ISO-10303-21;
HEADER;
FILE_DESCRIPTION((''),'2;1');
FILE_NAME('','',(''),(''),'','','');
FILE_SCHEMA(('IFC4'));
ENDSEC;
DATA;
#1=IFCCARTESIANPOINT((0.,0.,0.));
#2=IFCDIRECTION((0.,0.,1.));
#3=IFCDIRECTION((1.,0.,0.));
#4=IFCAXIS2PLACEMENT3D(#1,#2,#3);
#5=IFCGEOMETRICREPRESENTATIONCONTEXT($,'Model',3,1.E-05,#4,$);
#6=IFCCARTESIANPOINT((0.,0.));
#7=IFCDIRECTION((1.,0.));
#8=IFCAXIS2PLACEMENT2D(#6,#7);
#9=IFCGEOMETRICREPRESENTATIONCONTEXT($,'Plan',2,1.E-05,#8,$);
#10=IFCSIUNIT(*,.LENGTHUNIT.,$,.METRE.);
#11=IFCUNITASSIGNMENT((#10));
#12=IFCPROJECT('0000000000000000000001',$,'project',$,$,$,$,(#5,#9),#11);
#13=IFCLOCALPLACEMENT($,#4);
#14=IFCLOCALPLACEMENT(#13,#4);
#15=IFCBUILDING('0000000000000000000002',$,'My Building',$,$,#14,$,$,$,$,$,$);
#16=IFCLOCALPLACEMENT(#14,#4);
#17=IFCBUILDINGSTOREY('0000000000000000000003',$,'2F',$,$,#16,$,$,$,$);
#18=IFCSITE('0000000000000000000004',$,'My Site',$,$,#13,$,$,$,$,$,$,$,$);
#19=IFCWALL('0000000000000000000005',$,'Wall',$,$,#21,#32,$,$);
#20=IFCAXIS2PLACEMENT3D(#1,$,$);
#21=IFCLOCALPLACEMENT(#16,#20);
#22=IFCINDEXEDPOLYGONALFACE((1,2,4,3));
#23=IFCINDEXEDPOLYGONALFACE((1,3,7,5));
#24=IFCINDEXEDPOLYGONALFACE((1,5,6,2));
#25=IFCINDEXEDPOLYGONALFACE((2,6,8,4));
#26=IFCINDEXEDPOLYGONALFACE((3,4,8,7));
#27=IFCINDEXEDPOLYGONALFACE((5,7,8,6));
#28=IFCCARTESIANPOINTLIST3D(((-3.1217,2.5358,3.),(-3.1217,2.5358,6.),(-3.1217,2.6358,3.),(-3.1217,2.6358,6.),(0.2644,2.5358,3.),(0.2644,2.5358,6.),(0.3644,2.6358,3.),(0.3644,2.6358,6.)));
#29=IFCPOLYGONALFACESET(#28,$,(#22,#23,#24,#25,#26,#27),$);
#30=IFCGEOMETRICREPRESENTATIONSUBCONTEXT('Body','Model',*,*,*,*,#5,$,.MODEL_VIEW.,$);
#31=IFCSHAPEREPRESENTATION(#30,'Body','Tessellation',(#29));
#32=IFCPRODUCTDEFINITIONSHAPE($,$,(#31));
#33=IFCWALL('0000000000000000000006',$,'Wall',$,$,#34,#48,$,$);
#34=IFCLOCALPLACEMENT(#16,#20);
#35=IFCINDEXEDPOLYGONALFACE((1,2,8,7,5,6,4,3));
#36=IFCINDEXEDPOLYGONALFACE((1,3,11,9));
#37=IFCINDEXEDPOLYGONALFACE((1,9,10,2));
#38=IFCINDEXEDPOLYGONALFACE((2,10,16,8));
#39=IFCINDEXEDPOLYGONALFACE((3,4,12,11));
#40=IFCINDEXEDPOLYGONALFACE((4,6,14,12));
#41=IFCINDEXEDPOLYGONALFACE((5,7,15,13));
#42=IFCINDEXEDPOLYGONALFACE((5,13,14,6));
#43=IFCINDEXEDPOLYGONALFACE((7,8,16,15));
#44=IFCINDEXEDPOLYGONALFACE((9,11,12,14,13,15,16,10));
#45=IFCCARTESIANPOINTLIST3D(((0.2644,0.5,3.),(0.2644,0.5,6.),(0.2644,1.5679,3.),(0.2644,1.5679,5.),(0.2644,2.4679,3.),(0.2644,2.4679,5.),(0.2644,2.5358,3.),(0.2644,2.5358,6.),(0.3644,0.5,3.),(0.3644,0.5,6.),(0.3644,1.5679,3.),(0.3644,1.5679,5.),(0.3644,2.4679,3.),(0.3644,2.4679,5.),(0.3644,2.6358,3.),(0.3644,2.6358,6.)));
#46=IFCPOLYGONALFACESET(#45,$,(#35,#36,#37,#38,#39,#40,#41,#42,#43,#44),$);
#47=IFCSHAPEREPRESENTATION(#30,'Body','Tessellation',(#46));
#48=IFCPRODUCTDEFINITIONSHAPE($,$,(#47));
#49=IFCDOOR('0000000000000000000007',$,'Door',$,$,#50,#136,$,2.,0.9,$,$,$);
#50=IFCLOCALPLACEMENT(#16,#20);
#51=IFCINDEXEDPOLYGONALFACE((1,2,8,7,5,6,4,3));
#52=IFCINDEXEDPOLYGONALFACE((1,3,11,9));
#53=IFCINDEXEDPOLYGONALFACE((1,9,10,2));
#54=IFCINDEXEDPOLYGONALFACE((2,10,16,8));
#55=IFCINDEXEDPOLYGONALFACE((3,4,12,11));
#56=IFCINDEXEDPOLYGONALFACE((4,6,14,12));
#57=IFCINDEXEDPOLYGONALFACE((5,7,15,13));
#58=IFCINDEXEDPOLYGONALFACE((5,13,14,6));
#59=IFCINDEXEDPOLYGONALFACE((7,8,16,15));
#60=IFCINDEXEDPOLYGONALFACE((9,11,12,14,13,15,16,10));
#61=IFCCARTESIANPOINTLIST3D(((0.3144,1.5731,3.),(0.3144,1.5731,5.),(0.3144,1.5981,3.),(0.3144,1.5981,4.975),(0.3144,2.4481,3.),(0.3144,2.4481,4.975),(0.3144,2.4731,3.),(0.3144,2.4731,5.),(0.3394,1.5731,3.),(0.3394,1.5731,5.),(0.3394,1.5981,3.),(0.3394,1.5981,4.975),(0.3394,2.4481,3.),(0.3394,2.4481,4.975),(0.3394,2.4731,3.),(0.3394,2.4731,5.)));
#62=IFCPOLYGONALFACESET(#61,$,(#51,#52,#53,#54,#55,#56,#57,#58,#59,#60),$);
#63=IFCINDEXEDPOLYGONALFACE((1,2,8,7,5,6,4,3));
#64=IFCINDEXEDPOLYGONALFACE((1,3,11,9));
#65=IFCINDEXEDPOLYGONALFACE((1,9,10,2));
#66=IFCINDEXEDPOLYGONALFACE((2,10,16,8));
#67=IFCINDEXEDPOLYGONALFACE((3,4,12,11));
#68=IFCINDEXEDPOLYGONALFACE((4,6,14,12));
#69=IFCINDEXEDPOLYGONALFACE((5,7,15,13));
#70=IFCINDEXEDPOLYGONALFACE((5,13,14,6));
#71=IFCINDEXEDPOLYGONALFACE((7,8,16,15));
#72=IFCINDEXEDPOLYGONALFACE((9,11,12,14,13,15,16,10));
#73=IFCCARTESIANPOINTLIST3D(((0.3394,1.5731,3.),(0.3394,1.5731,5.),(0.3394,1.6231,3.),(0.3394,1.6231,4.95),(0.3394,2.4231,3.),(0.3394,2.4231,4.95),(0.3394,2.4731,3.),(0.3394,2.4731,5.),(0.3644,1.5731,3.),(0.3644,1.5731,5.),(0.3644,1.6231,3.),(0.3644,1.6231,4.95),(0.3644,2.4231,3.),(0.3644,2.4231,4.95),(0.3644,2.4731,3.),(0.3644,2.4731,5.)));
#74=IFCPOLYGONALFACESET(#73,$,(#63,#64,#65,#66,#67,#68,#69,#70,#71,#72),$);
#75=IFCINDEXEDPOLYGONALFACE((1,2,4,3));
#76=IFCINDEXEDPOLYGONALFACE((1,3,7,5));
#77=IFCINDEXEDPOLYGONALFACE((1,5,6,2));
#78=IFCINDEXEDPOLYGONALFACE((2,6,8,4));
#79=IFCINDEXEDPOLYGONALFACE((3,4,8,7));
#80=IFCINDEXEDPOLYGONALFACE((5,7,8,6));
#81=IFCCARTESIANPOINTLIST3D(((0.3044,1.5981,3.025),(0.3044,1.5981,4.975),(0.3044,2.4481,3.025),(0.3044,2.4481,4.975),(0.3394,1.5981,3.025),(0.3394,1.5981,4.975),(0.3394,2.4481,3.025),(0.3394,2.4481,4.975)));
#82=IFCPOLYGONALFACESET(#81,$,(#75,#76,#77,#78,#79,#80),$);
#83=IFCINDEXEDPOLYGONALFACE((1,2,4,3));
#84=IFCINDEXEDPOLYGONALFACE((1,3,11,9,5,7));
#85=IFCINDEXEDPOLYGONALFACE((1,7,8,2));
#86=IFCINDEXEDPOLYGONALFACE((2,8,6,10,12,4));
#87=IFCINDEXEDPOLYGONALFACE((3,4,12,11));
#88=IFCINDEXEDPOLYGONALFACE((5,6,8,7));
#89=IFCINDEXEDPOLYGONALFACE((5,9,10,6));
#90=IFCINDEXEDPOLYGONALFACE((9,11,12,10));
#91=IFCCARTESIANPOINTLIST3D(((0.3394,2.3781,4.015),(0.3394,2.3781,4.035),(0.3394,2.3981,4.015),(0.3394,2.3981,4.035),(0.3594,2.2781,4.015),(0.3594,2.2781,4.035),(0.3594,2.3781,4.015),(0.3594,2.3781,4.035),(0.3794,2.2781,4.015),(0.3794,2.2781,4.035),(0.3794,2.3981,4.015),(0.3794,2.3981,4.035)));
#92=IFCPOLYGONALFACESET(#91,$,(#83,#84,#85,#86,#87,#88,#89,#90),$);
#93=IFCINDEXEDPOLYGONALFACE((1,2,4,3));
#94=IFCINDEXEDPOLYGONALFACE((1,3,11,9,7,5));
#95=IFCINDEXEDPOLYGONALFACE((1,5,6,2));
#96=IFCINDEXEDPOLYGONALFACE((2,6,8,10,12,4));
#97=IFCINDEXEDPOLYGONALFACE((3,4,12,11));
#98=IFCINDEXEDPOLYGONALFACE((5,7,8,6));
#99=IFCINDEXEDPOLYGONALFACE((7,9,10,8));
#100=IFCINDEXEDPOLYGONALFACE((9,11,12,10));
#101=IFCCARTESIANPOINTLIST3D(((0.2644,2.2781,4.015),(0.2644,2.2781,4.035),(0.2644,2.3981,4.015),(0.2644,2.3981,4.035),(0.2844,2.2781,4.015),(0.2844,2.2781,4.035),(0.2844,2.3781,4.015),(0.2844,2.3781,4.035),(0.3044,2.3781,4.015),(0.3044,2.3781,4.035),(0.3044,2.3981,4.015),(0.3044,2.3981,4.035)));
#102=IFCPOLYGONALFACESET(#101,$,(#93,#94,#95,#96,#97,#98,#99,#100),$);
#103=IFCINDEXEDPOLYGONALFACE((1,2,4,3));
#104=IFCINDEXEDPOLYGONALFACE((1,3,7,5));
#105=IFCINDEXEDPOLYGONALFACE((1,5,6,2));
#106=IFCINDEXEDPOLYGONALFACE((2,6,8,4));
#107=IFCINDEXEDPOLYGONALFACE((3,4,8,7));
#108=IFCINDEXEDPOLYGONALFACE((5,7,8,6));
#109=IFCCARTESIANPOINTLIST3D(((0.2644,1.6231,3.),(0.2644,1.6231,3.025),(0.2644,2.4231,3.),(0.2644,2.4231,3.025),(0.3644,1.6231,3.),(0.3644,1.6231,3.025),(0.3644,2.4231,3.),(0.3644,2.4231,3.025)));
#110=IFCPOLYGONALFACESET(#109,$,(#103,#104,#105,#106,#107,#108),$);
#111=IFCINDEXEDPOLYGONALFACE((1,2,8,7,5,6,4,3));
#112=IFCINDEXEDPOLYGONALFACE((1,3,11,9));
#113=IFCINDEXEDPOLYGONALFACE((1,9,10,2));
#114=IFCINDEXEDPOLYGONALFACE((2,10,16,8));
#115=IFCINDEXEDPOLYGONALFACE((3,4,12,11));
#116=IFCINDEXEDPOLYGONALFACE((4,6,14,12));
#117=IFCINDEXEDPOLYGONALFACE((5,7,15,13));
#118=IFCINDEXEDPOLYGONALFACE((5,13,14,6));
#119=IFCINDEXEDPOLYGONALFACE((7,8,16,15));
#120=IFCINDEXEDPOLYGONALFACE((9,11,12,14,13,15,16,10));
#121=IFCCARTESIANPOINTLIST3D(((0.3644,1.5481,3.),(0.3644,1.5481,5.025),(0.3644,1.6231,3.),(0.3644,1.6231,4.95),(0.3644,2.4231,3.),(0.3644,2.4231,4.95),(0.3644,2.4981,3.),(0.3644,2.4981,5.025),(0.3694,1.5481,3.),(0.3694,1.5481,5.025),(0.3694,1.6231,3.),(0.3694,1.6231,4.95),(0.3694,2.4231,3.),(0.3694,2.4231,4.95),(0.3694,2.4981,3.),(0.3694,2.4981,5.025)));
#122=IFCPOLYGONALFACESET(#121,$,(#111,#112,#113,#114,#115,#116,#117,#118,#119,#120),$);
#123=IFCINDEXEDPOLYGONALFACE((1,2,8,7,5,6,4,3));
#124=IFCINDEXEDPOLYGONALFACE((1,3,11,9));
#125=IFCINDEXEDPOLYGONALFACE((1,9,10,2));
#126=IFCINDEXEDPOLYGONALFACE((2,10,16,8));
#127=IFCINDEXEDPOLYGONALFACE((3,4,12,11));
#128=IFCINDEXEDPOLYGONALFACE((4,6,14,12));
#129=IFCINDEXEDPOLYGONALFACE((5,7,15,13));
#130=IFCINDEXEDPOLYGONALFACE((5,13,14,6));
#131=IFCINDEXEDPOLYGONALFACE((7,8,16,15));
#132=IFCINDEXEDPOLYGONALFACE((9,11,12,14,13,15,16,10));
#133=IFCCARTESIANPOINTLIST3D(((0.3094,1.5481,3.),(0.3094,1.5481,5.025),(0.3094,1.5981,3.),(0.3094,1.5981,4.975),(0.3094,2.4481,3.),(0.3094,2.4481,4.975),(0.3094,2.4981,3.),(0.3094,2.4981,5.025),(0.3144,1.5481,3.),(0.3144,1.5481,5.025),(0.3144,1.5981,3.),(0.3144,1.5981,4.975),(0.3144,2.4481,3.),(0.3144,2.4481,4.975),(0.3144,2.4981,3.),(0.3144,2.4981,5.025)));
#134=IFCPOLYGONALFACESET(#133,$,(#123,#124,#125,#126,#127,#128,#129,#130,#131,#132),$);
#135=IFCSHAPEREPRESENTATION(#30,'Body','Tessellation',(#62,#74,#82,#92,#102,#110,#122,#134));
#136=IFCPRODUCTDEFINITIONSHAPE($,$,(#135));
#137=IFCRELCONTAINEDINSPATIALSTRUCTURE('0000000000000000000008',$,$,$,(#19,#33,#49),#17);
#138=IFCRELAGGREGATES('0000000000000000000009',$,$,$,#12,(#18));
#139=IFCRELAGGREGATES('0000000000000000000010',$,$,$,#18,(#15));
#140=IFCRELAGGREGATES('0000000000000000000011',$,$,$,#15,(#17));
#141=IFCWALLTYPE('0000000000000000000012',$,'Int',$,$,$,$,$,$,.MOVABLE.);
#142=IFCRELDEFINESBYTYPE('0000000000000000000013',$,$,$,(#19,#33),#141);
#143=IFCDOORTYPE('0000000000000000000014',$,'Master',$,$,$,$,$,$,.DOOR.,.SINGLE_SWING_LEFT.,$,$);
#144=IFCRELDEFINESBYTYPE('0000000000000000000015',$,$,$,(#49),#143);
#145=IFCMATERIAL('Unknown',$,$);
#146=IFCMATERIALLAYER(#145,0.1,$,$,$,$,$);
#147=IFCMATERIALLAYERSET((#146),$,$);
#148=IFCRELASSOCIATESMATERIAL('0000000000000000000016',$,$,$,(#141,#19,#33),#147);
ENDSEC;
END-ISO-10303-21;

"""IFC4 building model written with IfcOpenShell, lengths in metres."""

from ifc_helpers import new_model, entity, si_unit, frame, origin_with_axes, origin_2d_with_axis, place, context, subcontext, project, spatial, line, indexed_curve, outline, extrude, shape, source, transform, mapped, material, layer, layer_set, layer_usage, type_object, type_shapes, element, fill, save


model = new_model("IFC4")

# Units and contexts
model_context = context("Model", 3, precision=1e-05, world=origin_with_axes())
plan_context = context("Plan", 2, precision=1e-05, world=origin_2d_with_axis())
body_context_1 = subcontext(model_context, "Body", "Model", "MODEL_VIEW")
body_context_2 = subcontext(plan_context, "Body", "Plan", "PLAN_VIEW")
ifc_project = project(units=[si_unit("LENGTHUNIT", "METRE")], contexts=[model_context, plan_context])

# Site, building, storey
site_placement = place(None, origin_with_axes())
site = spatial("IfcSite", under=ifc_project, at=site_placement, Name="My Site")
building_placement = place(site_placement, origin_with_axes())
building = spatial("IfcBuilding", under=site, at=building_placement, Name="My Building")
storey_placement = place(building_placement, origin_with_axes())
storey = spatial("IfcBuildingStorey", under=building, at=storey_placement, Name="2F")

# Shared definitions
ifc_material = material(Name="Unknown")

# Wall
ifc_layer_1 = layer(ifc_material, 0.1)
ifc_layer_set_1 = layer_set([ifc_layer_1])
ifc_layer_usage_1 = layer_usage(ifc_layer_set_1, "AXIS2", "POSITIVE", 0.0)
wall_type_1 = type_object("IfcWallType", Name="Int", PredefinedType="MOVABLE", material=ifc_layer_set_1)
wall_1_placement = place(storey_placement, frame((-3.1217, 2.5358, 3.0), z_axis=(0.0, 0.0, 1.0), x_axis=(1.0, 0.0, 0.0)))
element("IfcWall", 1, at=wall_1_placement, inside=storey, type_object=wall_type_1, material=ifc_layer_usage_1, Name="Wall", context=body_context_1, shape_type="SweptSolid", body=[
    extrude(outline(indexed_curve([(0.0, 0.0), (0.0, 0.1), (3.4861, 0.1), (3.3861, 0.0)], segments=[line(1, 2, 3, 4, 1)])), origin_with_axes(), (0.0, 0.0, 1.0), 3.0),
])

# Wall, opening, door
ifc_layer_usage_2 = layer_usage(ifc_layer_set_1, "AXIS2", "POSITIVE", 0.0)
wall_2_placement = place(storey_placement, frame((0.2644, 2.5358, 3.0), z_axis=(0.0, 0.0, 1.0), x_axis=(0.0, -1.0, 0.0)))
wall_2 = element("IfcWall", 2, at=wall_2_placement, inside=storey, type_object=wall_type_1, material=ifc_layer_usage_2, Name="Wall", context=body_context_1, shape_type="SweptSolid", body=[
    extrude(outline(indexed_curve([(0.0, 0.0), (-0.1, 0.1), (2.0358, 0.1), (2.0358, 0.0)], segments=[line(1, 2, 3, 4, 1)])), origin_with_axes(), (0.0, 0.0, 1.0), 3.0),
])
shared_shape_1 = source(origin_with_axes(), body_context_1, "Body", "SweptSolid", [
    extrude(outline(indexed_curve([(0.0, 0.0), (0.9, 0.0), (0.9, 2.0), (0.0, 2.0)], segments=[line(1, 2, 3, 4, 1)])), frame((0.0, -0.6, 0.0), z_axis=(0.0, -1.0, 0.0), x_axis=(1.0, 0.0, 0.0)), (0.0, 0.0, -1.0), 1.2),
])
opening_1_placement = place(wall_2_placement, frame((0.9679, 0.1, 0.0), z_axis=(0.0, 0.0, 1.0), x_axis=(-1.0, 0.0, 0.0)))
opening_1 = element("IfcOpeningElement", 3, at=opening_1_placement, cuts=wall_2, PredefinedType="OPENING", context=body_context_1, shape_type="MappedRepresentation", body=[
    mapped(shared_shape_1, transform((0.0, 0.0, 0.0), x_axis=(1.0, 0.0, 0.0), y_axis=(0.0, 1.0, 0.0), z_axis=(0.0, 0.0, 1.0), scale=1.0)),
])
door_type_1 = type_object("IfcDoorType", Name="Master", OperationType="SINGLE_SWING_LEFT", PredefinedType="DOOR")
shared_shape_2 = source(origin_with_axes(), body_context_1, "Body", "SweptSolid", [
    extrude(outline(indexed_curve([(0.0, 0.0), (0.0, 2.0), (0.9, 2.0), (0.9, 0.0), (0.875, 0.0), (0.875, 1.975), (0.025, 1.975), (0.025, 0.0)], segments=[line(1, 2, 3, 4, 5, 6, 7, 8, 1)])), frame((0.0, 0.025, 0.0), z_axis=(0.0, -1.0, 0.0), x_axis=(1.0, 0.0, 0.0)), (0.0, 0.0, -1.0), 0.025),
    extrude(outline(indexed_curve([(0.0, 0.0), (0.0, 2.0), (0.9, 2.0), (0.9, 0.0), (0.85, 0.0), (0.85, 1.95), (0.05, 1.95), (0.05, 0.0)], segments=[line(1, 2, 3, 4, 5, 6, 7, 8, 1)])), frame((0.0, 0.0, 0.0), z_axis=(0.0, -1.0, 0.0), x_axis=(1.0, 0.0, 0.0)), (0.0, 0.0, -1.0), 0.025),
    extrude(outline(indexed_curve([(0.0, 0.0), (0.85, 0.0), (0.85, 0.035), (0.0, 0.035)], segments=[line(1, 2, 3, 4, 1)])), frame((0.025, 0.025, 0.025), z_axis=(0.0, 0.0, 1.0), x_axis=(1.0, 0.0, 0.0)), (0.0, 0.0, 1.0), 1.95),
    extrude(outline(indexed_curve([(0.0, 0.0), (0.0, -0.04), (-0.12, -0.04), (-0.12, -0.02), (-0.02, -0.02), (-0.02, 0.0)], segments=[line(1, 2, 3, 4, 5, 6, 1)])), frame((0.825, 0.025, 1.015), z_axis=(0.0, 0.0, 1.0), x_axis=(1.0, 0.0, 0.0)), (0.0, 0.0, 1.0), 0.02),
    extrude(outline(indexed_curve([(0.0, 0.0), (0.0, 0.04), (-0.12, 0.04), (-0.12, 0.02), (-0.02, 0.02), (-0.02, 0.0)], segments=[line(1, 2, 3, 4, 5, 6, 1)])), frame((0.825, 0.06, 1.015), z_axis=(0.0, 0.0, 1.0), x_axis=(1.0, 0.0, 0.0)), (0.0, 0.0, 1.0), 0.02),
    extrude(outline(indexed_curve([(0.0, 0.0), (0.8, 0.0), (0.8, 0.1), (0.0, 0.1)], segments=[line(1, 2, 3, 4, 1)])), frame((0.05, 0.0, 0.0), z_axis=(0.0, 0.0, 1.0), x_axis=(1.0, 0.0, 0.0)), (0.0, 0.0, 1.0), 0.025),
    extrude(outline(indexed_curve([(0.0, 0.0), (0.0, 2.025), (0.95, 2.025), (0.95, 0.0), (0.875, 0.0), (0.875, 1.95), (0.075, 1.95), (0.075, 0.0)], segments=[line(1, 2, 3, 4, 5, 6, 7, 8, 1)])), frame((-0.025, -0.005, 0.0), z_axis=(0.0, -1.0, 0.0), x_axis=(1.0, 0.0, 0.0)), (0.0, 0.0, -1.0), 0.005),
    extrude(outline(indexed_curve([(0.0, 0.0), (0.0, 2.025), (0.95, 2.025), (0.95, 0.0), (0.9, 0.0), (0.9, 1.975), (0.05, 1.975), (0.05, 0.0)], segments=[line(1, 2, 3, 4, 5, 6, 7, 8, 1)])), frame((-0.025, 0.05, 0.0), z_axis=(0.0, -1.0, 0.0), x_axis=(1.0, 0.0, 0.0)), (0.0, 0.0, -1.0), 0.005),
])
shared_shape_3 = source(origin_with_axes(), body_context_2, "Body", "Curve2D", [
    entity("IfcIndexedPolyCurve", entity("IfcCartesianPointList2D", [[0.0, 0.0], [0.0, 0.05], [0.025, 0.05], [0.025, 0.025], [0.05, 0.025], [0.05, 0.0]]), [entity("IfcLineIndex", [1, 2, 3, 4, 5, 6, 1])]),
    entity("IfcIndexedPolyCurve", entity("IfcCartesianPointList2D", [[0.9, 0.0], [0.9, 0.05], [0.875, 0.05], [0.875, 0.025], [0.85, 0.025], [0.85, 0.0]]), [entity("IfcLineIndex", [1, 2, 3, 4, 5, 6, 1])]),
    entity("IfcTrimmedCurve", entity("IfcEllipse", entity("IfcAxis2Placement2D", entity("IfcCartesianPoint", [0.06, 0.05]), entity("IfcDirection", [1.0, 0.0])), 0.815, 0.85), [entity("IfcCartesianPoint", [0.875, 0.05])], [entity("IfcCartesianPoint", [0.06, 0.9])], True, "CARTESIAN"),
    entity("IfcIndexedPolyCurve", entity("IfcCartesianPointList2D", [[0.025, 0.05], [0.06, 0.05], [0.06, 0.9], [0.025, 0.9]]), [entity("IfcLineIndex", [1, 2, 3, 4, 1])]),
])
type_shapes(door_type_1, [shared_shape_2, shared_shape_3])
door_1_placement = place(opening_1_placement, frame((0.0052, 0.0, 0.0), z_axis=(0.0, 0.0, 1.0), x_axis=(1.0, 0.0, 0.0)))
door_1 = element("IfcDoor", 4, at=door_1_placement, inside=storey, type_object=door_type_1, Name="Door", OverallHeight=2.0, OverallWidth=0.9, shapes=[
    shape(body_context_1, "Body", "MappedRepresentation", [mapped(shared_shape_2, transform((0.0, 0.0, 0.0), x_axis=(1.0, 0.0, 0.0), y_axis=(0.0, 1.0, 0.0), z_axis=(0.0, 0.0, 1.0), scale=1.0))]),
    shape(body_context_2, "Body", "MappedRepresentation", [mapped(shared_shape_3, transform((0.0, 0.0, 0.0), x_axis=(1.0, 0.0, 0.0), y_axis=(0.0, 1.0, 0.0), z_axis=(0.0, 0.0, 1.0), scale=1.0))]),
])
fill(opening_1, door_1)

save(model, "model.ifc")
